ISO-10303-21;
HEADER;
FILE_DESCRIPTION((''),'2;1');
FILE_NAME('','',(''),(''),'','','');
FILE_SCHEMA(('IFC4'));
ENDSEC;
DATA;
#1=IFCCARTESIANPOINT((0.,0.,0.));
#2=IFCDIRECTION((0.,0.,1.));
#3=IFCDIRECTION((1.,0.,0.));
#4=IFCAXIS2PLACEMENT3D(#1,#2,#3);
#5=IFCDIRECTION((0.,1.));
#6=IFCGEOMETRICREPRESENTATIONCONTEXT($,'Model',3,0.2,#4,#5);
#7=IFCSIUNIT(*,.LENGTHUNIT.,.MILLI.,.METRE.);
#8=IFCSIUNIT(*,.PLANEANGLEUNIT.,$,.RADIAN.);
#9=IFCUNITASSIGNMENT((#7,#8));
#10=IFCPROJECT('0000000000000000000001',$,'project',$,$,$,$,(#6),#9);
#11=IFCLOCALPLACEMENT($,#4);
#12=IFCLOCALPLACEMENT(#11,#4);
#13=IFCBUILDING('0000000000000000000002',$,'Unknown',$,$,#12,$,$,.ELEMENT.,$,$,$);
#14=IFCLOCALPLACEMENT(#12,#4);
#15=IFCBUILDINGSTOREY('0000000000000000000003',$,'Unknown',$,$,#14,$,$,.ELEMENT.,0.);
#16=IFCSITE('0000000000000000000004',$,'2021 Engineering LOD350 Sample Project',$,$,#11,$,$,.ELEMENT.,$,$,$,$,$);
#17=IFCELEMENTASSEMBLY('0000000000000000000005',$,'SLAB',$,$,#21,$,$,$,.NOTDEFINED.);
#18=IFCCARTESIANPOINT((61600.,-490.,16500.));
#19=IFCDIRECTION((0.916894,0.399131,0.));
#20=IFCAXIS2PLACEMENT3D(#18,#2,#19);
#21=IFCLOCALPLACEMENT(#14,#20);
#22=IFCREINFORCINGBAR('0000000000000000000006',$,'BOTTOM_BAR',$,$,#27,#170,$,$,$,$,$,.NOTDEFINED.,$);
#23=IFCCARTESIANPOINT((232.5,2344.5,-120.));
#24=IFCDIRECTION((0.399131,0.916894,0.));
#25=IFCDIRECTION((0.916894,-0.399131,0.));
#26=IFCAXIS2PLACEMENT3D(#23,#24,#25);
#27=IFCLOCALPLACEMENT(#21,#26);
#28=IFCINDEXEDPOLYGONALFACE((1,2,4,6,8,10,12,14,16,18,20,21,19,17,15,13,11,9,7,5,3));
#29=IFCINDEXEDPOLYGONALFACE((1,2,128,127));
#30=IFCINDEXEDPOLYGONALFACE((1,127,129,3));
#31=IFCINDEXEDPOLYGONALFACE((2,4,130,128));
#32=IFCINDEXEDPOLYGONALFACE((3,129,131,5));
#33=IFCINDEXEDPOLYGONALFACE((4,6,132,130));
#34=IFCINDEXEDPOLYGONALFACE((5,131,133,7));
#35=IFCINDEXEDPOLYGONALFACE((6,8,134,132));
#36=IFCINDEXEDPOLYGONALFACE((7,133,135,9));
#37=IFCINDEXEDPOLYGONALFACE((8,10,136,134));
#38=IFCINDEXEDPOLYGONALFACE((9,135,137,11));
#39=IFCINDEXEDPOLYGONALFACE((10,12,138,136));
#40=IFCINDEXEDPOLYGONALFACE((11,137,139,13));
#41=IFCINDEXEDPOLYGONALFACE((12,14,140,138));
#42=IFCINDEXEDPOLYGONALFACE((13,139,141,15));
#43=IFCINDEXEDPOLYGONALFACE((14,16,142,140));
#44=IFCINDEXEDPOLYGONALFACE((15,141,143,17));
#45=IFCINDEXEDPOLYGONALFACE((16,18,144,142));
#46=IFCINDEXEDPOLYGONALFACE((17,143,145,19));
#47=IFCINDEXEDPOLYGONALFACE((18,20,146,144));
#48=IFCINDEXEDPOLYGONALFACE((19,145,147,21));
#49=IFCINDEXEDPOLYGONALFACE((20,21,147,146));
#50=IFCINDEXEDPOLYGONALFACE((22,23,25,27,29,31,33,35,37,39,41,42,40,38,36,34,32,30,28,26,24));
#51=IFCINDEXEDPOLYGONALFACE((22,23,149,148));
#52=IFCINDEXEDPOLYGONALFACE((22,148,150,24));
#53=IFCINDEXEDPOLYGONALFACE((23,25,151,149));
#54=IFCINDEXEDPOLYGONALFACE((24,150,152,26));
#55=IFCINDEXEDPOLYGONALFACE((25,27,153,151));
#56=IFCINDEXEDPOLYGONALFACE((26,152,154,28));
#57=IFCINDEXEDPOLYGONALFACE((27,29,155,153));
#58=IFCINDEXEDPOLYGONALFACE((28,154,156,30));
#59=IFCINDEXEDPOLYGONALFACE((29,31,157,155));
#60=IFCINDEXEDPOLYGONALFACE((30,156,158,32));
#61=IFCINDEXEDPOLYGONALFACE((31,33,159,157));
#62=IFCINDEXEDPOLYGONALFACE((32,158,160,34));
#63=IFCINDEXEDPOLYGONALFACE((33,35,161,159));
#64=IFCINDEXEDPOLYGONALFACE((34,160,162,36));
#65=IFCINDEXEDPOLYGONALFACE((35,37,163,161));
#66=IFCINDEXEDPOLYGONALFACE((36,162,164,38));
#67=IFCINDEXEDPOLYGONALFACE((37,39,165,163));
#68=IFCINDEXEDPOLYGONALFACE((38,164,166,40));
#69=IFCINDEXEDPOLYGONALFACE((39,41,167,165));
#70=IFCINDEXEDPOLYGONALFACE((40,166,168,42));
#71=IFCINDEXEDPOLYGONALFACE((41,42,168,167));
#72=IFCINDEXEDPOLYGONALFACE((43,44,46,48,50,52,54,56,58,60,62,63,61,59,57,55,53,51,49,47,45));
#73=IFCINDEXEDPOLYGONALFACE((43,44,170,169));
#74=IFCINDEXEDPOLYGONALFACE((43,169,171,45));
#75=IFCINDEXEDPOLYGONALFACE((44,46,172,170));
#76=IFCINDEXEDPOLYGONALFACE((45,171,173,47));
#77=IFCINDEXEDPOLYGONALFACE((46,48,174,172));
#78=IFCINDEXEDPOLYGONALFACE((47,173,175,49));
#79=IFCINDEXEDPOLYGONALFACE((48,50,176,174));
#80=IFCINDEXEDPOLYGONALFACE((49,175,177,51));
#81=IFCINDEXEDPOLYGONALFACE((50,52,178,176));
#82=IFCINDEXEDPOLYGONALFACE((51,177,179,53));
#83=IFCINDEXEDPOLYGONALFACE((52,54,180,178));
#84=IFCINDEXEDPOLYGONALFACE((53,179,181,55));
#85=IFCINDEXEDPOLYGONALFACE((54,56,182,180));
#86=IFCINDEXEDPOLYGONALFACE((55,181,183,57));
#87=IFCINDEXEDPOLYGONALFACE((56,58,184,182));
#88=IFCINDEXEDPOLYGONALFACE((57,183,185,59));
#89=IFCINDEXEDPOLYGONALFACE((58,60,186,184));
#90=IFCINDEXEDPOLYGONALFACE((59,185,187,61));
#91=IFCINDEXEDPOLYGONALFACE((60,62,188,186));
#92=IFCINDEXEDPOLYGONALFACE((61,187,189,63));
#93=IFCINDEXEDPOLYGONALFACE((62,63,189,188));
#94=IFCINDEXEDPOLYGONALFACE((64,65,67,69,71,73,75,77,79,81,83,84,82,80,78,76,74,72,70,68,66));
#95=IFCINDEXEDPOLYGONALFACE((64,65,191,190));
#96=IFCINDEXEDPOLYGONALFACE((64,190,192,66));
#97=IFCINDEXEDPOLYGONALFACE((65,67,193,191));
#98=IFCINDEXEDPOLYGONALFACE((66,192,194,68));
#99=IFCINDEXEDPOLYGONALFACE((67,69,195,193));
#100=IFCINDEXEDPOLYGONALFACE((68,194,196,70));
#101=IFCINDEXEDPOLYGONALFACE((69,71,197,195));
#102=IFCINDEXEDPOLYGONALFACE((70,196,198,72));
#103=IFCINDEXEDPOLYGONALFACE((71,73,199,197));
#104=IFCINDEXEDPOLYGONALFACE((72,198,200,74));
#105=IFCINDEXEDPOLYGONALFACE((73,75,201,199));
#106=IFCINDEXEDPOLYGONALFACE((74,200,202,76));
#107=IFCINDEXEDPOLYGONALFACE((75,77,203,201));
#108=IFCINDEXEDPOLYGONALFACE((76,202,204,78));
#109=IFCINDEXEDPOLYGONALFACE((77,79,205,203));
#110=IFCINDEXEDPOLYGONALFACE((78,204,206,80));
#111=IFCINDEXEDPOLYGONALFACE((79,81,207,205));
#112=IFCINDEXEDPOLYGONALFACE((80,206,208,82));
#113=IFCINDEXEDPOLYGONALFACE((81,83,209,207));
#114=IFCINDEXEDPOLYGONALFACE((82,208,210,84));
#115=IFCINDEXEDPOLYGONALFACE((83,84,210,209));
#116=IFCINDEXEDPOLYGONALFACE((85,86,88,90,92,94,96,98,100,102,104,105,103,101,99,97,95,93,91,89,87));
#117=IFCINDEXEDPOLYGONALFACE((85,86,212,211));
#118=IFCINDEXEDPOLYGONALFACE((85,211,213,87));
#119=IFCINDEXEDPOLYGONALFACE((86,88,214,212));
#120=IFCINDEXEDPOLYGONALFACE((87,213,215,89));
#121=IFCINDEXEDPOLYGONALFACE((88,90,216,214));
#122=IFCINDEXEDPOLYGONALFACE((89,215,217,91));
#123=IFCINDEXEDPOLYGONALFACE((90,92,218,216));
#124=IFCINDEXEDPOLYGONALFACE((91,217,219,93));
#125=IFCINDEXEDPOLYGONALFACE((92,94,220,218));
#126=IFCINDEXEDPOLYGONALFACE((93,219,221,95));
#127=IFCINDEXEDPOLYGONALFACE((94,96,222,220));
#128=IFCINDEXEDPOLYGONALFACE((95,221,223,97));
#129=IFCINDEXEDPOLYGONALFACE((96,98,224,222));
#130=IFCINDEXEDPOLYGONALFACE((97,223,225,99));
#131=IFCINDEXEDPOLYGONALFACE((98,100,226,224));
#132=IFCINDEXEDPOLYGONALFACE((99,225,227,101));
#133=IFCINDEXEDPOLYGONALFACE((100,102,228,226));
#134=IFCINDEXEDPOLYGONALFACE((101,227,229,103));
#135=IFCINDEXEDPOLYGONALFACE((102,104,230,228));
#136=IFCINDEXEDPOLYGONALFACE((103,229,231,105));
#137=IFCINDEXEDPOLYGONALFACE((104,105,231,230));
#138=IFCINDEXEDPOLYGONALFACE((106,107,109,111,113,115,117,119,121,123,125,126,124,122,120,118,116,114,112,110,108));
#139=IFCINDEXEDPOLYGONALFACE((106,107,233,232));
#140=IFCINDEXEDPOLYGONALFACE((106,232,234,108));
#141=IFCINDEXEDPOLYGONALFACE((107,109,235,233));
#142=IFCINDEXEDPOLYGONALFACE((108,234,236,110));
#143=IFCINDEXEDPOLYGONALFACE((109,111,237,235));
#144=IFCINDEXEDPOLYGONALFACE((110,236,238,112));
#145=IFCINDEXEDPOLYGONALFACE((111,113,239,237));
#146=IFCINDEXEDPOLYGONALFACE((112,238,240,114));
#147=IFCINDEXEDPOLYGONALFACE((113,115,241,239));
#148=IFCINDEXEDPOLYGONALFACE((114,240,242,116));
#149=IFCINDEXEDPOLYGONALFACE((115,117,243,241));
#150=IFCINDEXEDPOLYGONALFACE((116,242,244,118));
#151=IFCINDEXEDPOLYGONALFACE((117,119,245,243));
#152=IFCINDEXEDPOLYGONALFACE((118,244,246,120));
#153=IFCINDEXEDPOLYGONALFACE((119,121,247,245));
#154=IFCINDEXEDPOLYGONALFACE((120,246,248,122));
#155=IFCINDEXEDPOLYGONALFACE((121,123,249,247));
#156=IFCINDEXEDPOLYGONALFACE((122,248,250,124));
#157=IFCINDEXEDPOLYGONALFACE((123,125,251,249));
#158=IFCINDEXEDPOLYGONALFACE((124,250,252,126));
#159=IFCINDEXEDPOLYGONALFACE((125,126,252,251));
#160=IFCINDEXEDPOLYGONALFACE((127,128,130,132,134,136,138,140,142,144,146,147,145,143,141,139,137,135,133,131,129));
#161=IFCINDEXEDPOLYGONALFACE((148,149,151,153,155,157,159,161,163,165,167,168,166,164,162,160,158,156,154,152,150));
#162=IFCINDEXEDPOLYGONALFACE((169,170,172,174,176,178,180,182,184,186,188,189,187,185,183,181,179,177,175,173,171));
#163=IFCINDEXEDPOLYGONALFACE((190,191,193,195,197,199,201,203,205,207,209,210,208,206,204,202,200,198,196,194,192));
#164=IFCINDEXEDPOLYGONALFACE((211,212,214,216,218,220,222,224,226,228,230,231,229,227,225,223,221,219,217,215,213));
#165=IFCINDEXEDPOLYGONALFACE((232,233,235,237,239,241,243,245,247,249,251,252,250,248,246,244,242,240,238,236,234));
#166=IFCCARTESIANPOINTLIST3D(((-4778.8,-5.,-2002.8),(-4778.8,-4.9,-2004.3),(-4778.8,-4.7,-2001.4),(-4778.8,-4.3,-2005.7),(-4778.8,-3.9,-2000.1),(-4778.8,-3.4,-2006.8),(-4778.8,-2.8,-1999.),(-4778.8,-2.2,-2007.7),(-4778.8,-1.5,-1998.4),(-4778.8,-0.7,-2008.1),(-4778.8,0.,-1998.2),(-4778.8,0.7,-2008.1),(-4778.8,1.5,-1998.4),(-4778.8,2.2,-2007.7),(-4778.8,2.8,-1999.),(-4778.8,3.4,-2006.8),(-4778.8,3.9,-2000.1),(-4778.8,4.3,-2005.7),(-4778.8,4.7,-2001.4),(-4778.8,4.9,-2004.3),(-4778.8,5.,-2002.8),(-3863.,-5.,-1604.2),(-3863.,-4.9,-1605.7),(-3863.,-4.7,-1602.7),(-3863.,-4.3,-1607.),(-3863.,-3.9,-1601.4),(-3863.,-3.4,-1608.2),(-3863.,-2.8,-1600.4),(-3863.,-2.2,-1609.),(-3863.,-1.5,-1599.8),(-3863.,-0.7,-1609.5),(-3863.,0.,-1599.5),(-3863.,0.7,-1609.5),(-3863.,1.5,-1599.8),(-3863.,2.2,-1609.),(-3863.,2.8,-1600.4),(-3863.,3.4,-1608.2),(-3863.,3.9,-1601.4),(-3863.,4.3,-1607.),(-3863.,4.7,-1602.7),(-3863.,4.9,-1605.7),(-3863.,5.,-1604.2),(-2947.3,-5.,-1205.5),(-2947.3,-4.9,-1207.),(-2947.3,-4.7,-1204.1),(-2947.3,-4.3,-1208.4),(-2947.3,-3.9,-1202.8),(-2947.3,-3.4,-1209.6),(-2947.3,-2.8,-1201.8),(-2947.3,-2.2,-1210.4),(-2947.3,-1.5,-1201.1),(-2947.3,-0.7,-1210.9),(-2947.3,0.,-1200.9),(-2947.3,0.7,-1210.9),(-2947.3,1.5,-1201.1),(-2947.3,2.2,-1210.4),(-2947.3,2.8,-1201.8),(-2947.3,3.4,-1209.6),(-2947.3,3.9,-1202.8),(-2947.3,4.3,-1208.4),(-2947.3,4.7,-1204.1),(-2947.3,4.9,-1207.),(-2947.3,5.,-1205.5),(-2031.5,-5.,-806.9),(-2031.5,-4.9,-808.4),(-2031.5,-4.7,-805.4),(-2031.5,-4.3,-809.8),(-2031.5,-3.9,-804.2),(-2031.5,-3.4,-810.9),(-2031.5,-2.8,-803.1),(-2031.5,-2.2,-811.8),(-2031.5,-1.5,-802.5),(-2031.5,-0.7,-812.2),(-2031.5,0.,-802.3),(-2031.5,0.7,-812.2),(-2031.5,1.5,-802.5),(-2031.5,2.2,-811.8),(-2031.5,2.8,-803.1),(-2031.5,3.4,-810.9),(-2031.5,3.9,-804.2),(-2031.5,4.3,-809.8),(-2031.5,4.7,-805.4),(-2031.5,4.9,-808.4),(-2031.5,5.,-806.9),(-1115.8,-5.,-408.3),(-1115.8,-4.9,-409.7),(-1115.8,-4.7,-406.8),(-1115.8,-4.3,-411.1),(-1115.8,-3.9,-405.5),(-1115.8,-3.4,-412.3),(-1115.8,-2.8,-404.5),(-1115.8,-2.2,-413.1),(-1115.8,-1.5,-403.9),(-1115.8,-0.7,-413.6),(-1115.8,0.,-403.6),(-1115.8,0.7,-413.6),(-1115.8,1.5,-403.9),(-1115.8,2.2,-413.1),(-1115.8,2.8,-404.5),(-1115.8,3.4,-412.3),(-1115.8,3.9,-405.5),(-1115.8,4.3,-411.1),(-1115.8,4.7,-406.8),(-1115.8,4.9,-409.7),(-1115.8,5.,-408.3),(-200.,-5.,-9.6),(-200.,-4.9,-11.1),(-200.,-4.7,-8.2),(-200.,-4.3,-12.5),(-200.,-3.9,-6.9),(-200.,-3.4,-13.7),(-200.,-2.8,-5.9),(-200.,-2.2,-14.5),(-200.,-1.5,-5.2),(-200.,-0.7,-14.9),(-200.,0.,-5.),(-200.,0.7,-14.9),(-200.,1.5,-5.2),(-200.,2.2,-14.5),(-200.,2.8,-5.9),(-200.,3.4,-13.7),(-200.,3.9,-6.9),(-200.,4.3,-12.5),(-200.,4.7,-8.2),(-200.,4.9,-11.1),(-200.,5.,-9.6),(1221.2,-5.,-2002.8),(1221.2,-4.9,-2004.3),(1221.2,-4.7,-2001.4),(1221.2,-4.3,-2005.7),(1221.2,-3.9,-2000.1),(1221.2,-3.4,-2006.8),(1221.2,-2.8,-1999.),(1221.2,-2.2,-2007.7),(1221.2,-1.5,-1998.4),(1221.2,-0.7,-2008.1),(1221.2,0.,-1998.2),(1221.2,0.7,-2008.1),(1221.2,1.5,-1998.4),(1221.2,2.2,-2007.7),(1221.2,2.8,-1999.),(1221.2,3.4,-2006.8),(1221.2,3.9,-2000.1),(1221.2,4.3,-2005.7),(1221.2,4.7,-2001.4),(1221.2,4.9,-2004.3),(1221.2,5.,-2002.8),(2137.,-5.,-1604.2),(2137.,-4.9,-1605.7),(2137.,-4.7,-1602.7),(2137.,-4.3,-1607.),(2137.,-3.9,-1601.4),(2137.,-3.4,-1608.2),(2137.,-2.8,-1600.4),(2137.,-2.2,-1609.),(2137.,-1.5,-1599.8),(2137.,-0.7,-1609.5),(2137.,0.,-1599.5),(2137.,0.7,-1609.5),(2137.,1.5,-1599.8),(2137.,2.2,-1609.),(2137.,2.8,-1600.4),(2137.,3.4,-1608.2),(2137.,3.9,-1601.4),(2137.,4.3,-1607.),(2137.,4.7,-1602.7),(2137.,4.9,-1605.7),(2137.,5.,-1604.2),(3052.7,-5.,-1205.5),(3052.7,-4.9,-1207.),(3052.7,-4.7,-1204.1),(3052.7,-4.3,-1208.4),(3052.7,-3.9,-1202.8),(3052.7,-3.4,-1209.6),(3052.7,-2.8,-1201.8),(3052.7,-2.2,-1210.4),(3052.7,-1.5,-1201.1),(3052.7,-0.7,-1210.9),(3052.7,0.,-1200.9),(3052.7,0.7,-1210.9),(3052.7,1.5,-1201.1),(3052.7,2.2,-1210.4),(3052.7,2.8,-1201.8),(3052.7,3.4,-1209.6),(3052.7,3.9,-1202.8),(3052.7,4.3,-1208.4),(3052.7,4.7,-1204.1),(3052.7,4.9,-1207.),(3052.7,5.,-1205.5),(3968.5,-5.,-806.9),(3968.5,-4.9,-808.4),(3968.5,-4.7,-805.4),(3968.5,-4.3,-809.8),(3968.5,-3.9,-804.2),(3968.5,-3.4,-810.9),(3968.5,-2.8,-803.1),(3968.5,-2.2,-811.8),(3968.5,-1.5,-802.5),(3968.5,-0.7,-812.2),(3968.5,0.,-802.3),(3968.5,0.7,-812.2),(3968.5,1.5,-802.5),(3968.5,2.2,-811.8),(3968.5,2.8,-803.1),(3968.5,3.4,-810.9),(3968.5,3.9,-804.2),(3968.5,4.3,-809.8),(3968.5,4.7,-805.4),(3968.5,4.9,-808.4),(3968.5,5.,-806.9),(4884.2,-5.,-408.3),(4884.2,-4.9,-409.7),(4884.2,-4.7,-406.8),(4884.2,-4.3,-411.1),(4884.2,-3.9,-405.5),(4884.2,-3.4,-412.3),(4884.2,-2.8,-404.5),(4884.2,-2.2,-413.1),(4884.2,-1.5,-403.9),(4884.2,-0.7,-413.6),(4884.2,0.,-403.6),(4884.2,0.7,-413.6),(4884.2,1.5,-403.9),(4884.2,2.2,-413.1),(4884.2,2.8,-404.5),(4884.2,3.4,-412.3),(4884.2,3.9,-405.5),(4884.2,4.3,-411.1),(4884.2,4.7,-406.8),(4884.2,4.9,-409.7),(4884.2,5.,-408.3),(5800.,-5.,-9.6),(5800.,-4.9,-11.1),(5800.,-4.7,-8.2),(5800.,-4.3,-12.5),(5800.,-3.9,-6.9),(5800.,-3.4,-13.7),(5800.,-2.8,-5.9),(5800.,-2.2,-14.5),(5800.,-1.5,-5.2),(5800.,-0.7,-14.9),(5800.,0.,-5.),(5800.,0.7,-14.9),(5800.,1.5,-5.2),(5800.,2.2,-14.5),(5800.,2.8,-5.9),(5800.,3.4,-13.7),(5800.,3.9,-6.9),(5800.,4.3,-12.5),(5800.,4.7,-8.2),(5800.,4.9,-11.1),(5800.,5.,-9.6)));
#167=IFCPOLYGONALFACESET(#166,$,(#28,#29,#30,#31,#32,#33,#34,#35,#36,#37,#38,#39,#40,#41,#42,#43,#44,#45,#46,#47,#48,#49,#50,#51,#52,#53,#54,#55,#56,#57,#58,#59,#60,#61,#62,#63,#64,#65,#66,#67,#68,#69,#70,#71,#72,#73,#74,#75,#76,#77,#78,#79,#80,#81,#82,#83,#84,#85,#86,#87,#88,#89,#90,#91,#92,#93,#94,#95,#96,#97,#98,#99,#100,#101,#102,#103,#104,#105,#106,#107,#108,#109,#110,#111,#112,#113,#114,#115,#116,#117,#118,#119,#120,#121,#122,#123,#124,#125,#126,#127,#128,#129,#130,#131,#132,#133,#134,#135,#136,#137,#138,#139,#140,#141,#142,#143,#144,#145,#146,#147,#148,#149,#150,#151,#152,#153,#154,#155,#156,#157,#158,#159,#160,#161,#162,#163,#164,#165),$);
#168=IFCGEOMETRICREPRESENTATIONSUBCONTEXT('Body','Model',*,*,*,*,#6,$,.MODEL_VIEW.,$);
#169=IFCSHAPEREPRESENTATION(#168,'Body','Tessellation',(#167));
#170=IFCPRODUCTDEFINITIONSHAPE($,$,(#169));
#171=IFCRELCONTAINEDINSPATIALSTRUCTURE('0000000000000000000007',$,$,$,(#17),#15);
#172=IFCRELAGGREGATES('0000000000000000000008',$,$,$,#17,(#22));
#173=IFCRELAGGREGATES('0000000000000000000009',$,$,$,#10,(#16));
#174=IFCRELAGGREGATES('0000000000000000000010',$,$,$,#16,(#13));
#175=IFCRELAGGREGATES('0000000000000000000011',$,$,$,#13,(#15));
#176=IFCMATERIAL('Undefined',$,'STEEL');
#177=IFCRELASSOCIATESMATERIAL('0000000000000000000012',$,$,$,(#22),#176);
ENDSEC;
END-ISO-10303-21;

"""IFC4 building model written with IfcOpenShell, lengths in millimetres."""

from ifc_helpers import new_model, entity, si_unit, direction, frame, origin_with_axes, place, context, subcontext, project, spatial, source, transform, mapped, material, element, aggregate, save


model = new_model("IFC4")

# Units and contexts
model_context = context("Model", 3, precision=0.2, world=origin_with_axes(), true_north=direction((0.0, 1.0)))
body_context = subcontext(model_context, "Body", "Model", "MODEL_VIEW")
ifc_project = project(units=[si_unit("LENGTHUNIT", "METRE", prefix="MILLI"), si_unit("PLANEANGLEUNIT", "RADIAN")], contexts=[model_context])

# Site, building, storey
site_placement = place(None, origin_with_axes())
site = spatial("IfcSite", under=ifc_project, at=site_placement, Name="2021 Engineering LOD350 Sample Project", CompositionType="ELEMENT")
building_placement = place(site_placement, origin_with_axes())
building = spatial("IfcBuilding", under=site, at=building_placement, Name="Unknown", CompositionType="ELEMENT")
storey_placement = place(building_placement, origin_with_axes())
storey = spatial("IfcBuildingStorey", under=building, at=storey_placement, Name="Unknown", CompositionType="ELEMENT", Elevation=0.0)

# Element assembly, reinforcing bar
assembly_1_placement = place(storey_placement, frame((61600.0, -490.0, 16500.0), z_axis=(0.0, 0.0, 1.0), x_axis=(0.916894, 0.399131, 0.0)))
assembly_1 = element("IfcElementAssembly", 1, at=assembly_1_placement, inside=storey, Name="SLAB", PredefinedType="NOTDEFINED")
ifc_material_1 = material(Name="Undefined", Category="STEEL")
shared_shape_1 = source(origin_with_axes(), body_context, "Body", "AdvancedSweptSolid", [
    entity("IfcSweptDiskSolid", entity("IfcIndexedPolyCurve", entity("IfcCartesianPointList3D", [[-200.0, 0.0, -10.0], [5800.0, 0.0, -10.0]]), [entity("IfcLineIndex", [1, 2])]), 5.0),
])
reinforcing_bar_1_placement = place(assembly_1_placement, frame((232.5, 2344.5, -120.0), z_axis=(0.399131, 0.916894, 0.0), x_axis=(0.916894, -0.399131, 0.0)))
reinforcing_bar_1 = element("IfcReinforcingBar", 2, at=reinforcing_bar_1_placement, material=ifc_material_1, Name="BOTTOM_BAR", PredefinedType="NOTDEFINED", context=body_context, shape_type="MappedRepresentation", body=[
    mapped(shared_shape_1, transform((0.0, 0.0, 0.0))),
    mapped(shared_shape_1, transform((-915.8, 0.0, -398.6))),
    mapped(shared_shape_1, transform((-1831.5, 0.0, -797.3))),
    mapped(shared_shape_1, transform((-2747.3, 0.0, -1195.9))),
    mapped(shared_shape_1, transform((-3663.0, 0.0, -1594.5))),
    mapped(shared_shape_1, transform((-4578.8, 0.0, -1993.2))),
])

aggregate(assembly_1, [reinforcing_bar_1])

save(model, "model.ifc")
